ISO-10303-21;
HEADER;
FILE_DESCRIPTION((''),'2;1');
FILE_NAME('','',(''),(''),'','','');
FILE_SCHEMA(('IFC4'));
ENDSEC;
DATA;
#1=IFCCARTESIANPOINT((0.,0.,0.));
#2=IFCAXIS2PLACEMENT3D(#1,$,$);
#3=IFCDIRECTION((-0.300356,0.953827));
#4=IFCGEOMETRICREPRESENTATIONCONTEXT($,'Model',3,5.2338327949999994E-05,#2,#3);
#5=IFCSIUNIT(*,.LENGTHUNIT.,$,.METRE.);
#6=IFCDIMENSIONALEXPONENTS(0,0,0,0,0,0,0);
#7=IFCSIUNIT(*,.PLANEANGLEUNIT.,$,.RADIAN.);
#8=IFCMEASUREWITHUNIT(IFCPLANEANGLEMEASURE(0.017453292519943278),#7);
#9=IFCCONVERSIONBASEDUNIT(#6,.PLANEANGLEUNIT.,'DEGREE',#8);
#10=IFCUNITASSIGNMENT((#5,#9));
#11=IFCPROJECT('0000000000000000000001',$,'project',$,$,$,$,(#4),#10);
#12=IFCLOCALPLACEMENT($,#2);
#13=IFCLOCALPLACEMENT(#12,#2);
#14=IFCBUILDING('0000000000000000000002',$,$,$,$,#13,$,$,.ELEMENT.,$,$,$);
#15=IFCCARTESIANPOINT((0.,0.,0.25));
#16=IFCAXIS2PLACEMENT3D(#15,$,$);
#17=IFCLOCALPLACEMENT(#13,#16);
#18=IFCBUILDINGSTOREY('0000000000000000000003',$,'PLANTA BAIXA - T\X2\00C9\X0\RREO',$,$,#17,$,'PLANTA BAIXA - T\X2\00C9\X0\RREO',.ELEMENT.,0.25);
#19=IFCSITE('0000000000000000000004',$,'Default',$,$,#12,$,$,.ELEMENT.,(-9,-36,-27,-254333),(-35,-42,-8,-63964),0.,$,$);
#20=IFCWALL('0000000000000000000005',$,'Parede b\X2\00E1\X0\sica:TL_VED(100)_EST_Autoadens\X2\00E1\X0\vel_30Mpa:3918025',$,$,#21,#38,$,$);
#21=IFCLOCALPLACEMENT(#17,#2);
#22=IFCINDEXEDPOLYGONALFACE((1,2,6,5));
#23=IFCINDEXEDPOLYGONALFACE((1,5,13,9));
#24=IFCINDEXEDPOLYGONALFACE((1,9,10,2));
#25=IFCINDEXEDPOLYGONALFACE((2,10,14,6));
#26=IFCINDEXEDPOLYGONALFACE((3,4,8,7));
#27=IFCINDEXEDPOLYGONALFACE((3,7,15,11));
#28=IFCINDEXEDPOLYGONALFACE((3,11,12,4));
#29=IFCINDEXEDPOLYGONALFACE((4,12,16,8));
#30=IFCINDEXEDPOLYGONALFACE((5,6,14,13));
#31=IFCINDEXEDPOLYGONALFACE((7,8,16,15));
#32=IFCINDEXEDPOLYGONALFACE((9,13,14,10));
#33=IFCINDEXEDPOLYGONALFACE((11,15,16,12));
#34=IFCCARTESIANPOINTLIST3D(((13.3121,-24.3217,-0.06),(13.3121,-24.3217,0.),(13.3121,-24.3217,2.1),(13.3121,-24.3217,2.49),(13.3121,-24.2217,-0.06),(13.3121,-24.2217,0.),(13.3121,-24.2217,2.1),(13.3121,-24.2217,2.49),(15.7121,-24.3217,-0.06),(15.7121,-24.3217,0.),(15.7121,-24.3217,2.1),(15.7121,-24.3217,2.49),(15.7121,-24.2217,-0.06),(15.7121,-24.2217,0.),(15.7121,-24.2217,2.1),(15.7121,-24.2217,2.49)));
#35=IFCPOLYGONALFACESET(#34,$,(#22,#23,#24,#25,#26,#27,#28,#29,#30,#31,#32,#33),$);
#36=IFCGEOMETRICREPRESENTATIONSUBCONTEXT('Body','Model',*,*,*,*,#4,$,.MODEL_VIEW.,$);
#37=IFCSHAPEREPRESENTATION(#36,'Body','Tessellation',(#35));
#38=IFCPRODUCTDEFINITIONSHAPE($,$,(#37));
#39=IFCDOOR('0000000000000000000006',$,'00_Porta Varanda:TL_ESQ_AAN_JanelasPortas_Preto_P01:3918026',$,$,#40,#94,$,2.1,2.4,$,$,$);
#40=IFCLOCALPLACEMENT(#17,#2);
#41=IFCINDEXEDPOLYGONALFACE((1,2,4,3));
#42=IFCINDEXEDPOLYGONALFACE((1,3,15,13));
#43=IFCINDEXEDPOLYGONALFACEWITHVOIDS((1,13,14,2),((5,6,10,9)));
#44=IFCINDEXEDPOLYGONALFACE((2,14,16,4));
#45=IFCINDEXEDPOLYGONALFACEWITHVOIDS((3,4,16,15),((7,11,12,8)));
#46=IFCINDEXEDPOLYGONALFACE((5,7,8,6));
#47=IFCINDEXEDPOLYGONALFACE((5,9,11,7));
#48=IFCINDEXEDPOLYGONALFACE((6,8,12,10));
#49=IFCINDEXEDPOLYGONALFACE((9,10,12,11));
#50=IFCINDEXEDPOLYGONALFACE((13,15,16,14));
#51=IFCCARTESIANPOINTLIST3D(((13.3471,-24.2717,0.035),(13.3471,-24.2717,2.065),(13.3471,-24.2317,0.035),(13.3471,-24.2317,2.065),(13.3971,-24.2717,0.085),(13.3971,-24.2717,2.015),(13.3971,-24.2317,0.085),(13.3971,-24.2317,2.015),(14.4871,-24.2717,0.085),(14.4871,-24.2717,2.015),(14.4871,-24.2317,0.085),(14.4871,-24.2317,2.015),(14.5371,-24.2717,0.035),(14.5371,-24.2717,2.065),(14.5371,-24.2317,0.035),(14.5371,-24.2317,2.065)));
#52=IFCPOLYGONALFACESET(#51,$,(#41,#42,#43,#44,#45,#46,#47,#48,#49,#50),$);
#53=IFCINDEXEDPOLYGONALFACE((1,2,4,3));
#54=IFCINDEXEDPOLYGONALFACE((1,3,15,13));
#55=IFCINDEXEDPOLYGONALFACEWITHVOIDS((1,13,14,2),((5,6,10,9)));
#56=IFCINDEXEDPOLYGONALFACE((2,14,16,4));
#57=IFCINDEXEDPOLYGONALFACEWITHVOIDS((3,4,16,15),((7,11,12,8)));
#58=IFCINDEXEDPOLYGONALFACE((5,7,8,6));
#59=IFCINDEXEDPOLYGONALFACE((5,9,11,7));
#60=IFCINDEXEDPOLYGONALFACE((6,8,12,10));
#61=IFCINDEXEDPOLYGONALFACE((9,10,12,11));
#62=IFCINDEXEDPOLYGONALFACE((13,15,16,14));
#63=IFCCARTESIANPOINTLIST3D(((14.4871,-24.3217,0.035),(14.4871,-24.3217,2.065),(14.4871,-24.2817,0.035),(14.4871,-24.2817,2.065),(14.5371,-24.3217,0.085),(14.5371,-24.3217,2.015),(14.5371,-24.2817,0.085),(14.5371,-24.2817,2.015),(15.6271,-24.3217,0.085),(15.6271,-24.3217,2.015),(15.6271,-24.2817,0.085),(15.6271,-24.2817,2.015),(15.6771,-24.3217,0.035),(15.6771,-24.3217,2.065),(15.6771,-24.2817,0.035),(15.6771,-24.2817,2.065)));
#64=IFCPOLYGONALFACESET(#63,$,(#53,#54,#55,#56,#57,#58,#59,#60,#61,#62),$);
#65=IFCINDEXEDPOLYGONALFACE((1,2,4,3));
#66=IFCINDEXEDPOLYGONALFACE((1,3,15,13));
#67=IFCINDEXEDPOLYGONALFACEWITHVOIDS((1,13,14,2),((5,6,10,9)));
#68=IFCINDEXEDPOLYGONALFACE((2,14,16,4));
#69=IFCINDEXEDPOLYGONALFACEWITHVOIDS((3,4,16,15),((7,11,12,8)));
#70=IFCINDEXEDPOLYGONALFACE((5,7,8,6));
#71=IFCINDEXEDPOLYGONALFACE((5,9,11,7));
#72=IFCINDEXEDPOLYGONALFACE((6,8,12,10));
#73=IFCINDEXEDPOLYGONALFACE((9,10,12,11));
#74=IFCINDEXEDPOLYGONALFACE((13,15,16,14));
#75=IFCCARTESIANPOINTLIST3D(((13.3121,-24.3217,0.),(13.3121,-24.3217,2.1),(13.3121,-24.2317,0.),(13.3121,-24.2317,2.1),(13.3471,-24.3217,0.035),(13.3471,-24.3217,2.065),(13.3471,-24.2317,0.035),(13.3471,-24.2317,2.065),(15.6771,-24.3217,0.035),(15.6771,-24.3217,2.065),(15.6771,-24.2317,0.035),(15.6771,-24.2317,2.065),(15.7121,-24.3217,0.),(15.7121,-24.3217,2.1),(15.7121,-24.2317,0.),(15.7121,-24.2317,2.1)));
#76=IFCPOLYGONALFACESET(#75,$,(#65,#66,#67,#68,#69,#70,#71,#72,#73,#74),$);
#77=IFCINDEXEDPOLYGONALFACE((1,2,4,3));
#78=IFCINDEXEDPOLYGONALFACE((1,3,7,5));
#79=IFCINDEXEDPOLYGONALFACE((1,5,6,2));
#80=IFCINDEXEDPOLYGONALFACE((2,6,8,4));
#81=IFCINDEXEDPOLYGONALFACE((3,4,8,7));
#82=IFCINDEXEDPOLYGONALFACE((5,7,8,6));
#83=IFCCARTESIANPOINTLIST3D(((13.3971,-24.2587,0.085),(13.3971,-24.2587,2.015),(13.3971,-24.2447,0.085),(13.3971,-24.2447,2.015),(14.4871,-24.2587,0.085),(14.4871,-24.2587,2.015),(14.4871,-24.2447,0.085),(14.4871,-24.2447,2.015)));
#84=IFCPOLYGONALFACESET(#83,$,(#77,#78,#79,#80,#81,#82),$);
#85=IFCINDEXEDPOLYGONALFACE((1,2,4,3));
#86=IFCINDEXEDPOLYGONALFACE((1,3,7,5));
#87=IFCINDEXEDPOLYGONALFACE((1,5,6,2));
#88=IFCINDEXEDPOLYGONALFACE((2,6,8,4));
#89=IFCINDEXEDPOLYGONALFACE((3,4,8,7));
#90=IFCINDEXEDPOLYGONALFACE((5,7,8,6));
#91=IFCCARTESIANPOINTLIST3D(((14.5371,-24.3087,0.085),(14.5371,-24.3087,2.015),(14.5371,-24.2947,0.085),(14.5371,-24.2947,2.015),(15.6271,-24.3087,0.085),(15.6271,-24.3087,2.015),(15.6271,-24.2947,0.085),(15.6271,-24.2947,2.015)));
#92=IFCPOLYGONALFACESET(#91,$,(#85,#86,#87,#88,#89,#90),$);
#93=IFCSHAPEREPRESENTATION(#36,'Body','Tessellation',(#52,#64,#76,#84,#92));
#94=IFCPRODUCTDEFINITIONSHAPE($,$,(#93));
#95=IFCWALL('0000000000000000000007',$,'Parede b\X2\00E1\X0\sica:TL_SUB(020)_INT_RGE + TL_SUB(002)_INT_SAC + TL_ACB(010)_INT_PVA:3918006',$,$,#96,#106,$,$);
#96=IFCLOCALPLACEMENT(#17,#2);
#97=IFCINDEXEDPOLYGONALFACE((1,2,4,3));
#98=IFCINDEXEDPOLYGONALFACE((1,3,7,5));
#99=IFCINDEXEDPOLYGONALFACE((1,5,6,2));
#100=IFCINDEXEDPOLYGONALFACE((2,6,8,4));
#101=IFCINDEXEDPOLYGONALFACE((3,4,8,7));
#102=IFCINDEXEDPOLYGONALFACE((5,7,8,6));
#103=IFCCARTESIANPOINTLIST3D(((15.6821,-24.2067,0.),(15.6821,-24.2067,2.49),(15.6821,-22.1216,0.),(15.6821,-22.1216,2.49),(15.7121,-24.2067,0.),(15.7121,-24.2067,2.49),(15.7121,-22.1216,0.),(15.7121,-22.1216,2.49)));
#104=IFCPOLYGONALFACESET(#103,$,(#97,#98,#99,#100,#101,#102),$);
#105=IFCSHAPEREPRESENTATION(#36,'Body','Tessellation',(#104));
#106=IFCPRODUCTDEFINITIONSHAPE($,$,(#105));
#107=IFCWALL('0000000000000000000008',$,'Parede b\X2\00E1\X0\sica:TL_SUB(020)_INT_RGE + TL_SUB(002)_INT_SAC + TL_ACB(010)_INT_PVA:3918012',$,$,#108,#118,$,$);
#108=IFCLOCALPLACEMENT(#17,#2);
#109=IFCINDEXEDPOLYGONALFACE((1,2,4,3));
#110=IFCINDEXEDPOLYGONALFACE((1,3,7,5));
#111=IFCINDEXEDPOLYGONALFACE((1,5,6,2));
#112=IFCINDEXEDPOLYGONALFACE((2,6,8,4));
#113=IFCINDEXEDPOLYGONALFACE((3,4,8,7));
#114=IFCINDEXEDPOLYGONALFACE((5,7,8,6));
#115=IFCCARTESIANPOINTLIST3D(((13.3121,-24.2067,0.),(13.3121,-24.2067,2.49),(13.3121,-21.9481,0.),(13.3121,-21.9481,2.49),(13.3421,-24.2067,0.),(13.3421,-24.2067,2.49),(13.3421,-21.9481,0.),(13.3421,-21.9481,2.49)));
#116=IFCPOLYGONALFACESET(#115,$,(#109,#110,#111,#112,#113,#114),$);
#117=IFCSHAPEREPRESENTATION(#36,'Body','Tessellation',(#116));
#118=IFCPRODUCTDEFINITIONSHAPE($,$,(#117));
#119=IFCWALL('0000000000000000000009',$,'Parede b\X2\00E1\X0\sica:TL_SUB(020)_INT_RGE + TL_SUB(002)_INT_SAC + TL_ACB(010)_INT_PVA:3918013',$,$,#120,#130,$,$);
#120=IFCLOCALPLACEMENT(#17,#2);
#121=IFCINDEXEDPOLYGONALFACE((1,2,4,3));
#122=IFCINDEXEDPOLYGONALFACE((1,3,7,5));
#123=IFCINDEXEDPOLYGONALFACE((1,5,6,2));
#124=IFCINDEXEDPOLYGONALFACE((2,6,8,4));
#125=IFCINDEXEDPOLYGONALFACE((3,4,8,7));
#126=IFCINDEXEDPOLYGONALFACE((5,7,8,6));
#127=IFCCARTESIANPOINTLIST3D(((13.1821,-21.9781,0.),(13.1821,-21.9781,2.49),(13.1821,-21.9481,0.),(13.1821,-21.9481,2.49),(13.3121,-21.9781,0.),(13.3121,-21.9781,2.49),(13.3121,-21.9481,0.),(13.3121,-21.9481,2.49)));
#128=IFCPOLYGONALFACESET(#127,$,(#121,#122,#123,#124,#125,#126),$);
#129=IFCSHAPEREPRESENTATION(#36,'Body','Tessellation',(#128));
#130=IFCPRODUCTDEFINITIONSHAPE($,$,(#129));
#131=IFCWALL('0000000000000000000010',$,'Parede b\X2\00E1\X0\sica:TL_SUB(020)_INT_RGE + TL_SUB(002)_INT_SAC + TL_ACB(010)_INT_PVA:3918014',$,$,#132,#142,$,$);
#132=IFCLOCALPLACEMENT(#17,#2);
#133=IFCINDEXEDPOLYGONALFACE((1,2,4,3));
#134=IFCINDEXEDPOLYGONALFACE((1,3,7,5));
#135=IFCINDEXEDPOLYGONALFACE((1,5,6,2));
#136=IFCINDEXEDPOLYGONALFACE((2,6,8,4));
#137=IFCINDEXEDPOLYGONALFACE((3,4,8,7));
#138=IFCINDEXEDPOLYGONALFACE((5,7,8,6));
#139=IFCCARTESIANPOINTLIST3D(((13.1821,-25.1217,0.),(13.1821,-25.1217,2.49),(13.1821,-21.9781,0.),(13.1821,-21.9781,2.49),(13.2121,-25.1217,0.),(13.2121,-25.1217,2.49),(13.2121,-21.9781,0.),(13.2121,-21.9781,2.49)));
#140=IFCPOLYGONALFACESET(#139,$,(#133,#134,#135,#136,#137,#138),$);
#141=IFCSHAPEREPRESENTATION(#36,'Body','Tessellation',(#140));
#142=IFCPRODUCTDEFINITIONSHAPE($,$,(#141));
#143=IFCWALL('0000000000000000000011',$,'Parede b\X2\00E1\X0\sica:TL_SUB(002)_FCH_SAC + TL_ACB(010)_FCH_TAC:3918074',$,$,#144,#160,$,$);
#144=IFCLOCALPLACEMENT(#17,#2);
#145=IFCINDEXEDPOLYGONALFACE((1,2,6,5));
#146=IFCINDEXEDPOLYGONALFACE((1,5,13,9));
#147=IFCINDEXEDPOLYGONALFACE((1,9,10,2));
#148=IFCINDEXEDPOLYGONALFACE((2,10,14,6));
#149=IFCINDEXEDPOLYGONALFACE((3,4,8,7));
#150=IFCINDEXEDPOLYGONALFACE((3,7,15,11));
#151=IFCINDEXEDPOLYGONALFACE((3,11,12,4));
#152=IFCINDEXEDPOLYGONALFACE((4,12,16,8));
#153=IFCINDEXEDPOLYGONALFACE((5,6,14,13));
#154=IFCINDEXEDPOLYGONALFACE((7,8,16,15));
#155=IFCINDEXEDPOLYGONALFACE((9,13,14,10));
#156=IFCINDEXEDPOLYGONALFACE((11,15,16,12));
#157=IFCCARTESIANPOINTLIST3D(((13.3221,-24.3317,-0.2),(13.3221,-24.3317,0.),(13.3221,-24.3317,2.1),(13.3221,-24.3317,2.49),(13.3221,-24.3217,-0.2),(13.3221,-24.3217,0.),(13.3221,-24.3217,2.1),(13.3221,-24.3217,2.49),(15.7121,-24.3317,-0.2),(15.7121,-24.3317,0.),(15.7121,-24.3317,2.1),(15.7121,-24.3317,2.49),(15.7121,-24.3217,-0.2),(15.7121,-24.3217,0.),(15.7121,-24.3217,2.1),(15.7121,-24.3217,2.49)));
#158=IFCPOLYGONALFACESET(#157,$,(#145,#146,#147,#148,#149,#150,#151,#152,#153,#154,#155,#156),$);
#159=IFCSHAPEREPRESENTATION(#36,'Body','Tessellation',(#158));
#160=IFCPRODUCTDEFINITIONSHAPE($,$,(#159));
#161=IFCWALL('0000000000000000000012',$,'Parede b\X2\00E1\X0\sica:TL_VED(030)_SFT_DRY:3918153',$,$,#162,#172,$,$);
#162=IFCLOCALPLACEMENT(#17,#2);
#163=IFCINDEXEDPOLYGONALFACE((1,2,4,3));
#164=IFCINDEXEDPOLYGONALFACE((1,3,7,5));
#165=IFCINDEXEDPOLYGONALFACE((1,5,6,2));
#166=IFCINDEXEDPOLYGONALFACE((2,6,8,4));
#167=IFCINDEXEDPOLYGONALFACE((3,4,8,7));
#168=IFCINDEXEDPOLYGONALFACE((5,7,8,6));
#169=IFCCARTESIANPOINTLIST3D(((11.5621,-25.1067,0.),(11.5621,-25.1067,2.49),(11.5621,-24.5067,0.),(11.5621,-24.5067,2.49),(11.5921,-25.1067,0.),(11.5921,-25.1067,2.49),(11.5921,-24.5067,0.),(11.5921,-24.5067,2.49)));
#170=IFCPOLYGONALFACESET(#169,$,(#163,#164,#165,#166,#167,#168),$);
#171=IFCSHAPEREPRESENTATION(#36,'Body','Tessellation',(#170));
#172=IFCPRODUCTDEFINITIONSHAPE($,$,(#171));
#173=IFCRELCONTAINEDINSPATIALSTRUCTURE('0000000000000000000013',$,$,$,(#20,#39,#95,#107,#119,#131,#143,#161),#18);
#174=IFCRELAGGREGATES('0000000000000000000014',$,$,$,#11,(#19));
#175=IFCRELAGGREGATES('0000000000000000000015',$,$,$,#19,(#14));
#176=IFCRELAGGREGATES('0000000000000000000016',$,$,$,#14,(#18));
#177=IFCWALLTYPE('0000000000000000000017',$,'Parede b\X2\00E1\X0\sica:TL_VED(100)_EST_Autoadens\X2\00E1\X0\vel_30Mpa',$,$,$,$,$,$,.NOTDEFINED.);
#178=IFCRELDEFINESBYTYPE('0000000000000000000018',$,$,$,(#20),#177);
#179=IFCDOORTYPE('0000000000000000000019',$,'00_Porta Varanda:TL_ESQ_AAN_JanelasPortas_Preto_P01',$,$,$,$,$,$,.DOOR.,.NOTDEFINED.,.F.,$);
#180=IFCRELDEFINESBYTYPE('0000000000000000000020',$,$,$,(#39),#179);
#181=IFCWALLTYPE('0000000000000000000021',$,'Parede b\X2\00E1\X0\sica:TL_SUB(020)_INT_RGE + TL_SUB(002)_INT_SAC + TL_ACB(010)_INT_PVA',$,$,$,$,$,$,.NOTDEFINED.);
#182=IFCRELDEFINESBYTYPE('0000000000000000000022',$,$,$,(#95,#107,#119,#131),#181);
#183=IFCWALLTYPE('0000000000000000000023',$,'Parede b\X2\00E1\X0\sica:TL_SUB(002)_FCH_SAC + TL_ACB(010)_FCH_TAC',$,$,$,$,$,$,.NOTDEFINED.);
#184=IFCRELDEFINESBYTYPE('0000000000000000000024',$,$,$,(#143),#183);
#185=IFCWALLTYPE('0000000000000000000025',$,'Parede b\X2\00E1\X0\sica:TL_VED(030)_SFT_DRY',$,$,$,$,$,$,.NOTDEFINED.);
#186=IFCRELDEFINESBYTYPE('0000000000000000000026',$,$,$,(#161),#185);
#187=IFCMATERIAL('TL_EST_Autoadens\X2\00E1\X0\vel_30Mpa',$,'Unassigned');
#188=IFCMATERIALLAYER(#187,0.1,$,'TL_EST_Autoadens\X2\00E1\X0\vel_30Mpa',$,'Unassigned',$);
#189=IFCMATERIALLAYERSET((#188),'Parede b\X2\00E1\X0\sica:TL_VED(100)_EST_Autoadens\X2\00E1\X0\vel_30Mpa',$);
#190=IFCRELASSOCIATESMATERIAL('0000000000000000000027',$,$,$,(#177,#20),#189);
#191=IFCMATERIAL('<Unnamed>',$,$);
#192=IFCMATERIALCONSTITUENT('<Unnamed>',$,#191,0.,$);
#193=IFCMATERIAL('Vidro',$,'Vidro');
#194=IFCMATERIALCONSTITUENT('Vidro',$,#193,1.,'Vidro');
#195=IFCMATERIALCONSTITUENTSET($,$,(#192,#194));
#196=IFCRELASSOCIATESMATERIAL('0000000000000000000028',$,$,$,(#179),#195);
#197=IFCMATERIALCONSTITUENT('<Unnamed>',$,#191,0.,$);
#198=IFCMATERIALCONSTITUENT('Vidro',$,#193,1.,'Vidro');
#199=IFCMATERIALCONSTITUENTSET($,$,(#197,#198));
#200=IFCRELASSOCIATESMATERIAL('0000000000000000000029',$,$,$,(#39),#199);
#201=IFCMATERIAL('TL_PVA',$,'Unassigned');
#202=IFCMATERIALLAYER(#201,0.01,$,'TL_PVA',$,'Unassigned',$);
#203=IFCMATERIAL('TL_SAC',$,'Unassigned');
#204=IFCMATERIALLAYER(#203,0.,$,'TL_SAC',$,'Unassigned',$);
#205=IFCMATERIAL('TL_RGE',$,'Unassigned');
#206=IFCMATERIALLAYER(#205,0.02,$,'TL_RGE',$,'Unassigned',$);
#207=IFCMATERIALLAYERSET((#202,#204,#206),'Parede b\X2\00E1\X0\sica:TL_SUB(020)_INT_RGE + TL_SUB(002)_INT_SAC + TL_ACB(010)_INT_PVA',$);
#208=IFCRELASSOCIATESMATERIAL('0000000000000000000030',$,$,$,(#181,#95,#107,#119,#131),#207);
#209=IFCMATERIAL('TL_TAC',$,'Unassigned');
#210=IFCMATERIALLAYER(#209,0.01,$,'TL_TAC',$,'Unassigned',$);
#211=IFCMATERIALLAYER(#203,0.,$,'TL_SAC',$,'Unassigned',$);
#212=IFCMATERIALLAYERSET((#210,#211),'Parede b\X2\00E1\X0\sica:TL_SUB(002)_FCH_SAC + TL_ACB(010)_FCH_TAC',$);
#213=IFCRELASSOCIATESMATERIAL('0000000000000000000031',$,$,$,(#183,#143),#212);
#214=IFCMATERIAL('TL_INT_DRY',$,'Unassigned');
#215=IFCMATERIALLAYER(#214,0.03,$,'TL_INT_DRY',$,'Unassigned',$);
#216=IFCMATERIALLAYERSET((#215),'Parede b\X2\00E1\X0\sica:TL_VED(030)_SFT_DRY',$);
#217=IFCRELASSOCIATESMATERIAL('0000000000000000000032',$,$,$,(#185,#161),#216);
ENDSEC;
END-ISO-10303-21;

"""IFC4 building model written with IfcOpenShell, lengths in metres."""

from ifc_helpers import new_model, entity, si_unit, converted_unit, direction, frame, frame_2d, origin, place, context, subcontext, project, spatial, polyline, rectangle, outline, extrude, source, transform, mapped, material, layer, layer_set, layer_usage, constituent, constituent_set, type_object, type_shapes, element, fill, save


model = new_model("IFC4")

# Units and contexts
model_context = context("Model", 3, precision=5.2338327949999994e-05, world=origin(), true_north=direction((-0.300356, 0.953827)))
body_context = subcontext(model_context, "Body", "Model", "MODEL_VIEW")
ifc_project = project(units=[si_unit("LENGTHUNIT", "METRE"), converted_unit("PLANEANGLEUNIT", "DEGREE", entity("IfcPlaneAngleMeasure", 0.017453292519943278), si_unit("PLANEANGLEUNIT", "RADIAN"), dimensions=[0, 0, 0, 0, 0, 0, 0])], contexts=[model_context])

# Site, building, storey
site_placement = place(None, origin())
site = spatial("IfcSite", under=ifc_project, at=site_placement, Name="Default", CompositionType="ELEMENT", RefLatitude=(-9, -36, -27, -254333), RefLongitude=(-35, -42, -8, -63964), RefElevation=0.0)
building_placement = place(site_placement, origin())
building = spatial("IfcBuilding", under=site, at=building_placement, CompositionType="ELEMENT")
storey_placement = place(building_placement, frame((0.0, 0.0, 0.25)))
storey = spatial("IfcBuildingStorey", under=building, at=storey_placement, Name="PLANTA BAIXA - TÉRREO", LongName="PLANTA BAIXA - TÉRREO", CompositionType="ELEMENT", Elevation=0.25)

# Shared definitions
ifc_material_1 = material(Name="TL_EST_Autoadensável_30Mpa", Category="Unassigned")
ifc_layer_1 = layer(ifc_material_1, 0.1, Name="TL_EST_Autoadensável_30Mpa", Category="Unassigned")
ifc_layer_set_1 = layer_set([ifc_layer_1], Name="Parede básica:TL_VED(100)_EST_Autoadensável_30Mpa")
wall_type_1 = type_object("IfcWallType", Name="Parede básica:TL_VED(100)_EST_Autoadensável_30Mpa", PredefinedType="NOTDEFINED", material=ifc_layer_set_1)

# Shared definitions
ifc_material_2 = material(Name="Vidro", Category="Vidro")

# Wall, opening, door
ifc_layer_usage_1 = layer_usage(ifc_layer_set_1, "AXIS2", "NEGATIVE", 0.05)
wall_1_placement = place(storey_placement, frame((15.7121, -24.2717, -0.06), z_axis=(0.0, 0.0, 1.0), x_axis=(-1.0, 0.0, 0.0)))
wall_1 = element("IfcWall", 1, at=wall_1_placement, inside=storey, type_object=wall_type_1, material=ifc_layer_usage_1, Name="Parede básica:TL_VED(100)_EST_Autoadensável_30Mpa:3918025", context=body_context, shape_type="SweptSolid", body=[
    extrude(rectangle(XDim=2.4, YDim=0.1, at=frame_2d((1.2, 0.0), x_axis=(-1.0, 0.0))), origin(), (0.0, 0.0, 1.0), 2.55),
])
opening_1_placement = place(wall_1_placement, frame((2.4, 0.05, 0.06)))
opening_1 = element("IfcOpeningElement", 2, at=opening_1_placement, cuts=wall_1, PredefinedType="OPENING", context=body_context, shape_type="SweptSolid", body=[
    extrude(rectangle(XDim=2.1, YDim=2.4, at=frame_2d((1.05, 1.2), x_axis=(1.0, 0.0))), frame((0.0, 0.0, 0.0), z_axis=(0.0, -1.0, 0.0), x_axis=(0.0, 0.0, 1.0)), (0.0, 0.0, 1.0), 0.1),
])
ifc_material_3 = material(Name="<Unnamed>")
ifc_constituent_1 = constituent(ifc_material_3, Name="<Unnamed>", fraction=0.0)
ifc_constituent_2 = constituent(ifc_material_2, Name="Vidro", Category="Vidro", fraction=1.0)
ifc_constituent_set_1 = constituent_set(constituents=[ifc_constituent_1, ifc_constituent_2])
ifc_constituent_3 = constituent(ifc_material_3, Name="<Unnamed>", fraction=0.0)
ifc_constituent_4 = constituent(ifc_material_2, Name="Vidro", Category="Vidro", fraction=1.0)
ifc_constituent_set_2 = constituent_set(constituents=[ifc_constituent_3, ifc_constituent_4])
door_type = type_object("IfcDoorType", Name="00_Porta Varanda:TL_ESQ_AAN_JanelasPortas_Preto_P01", OperationType="NOTDEFINED", ParameterTakesPrecedence=False, PredefinedType="DOOR", material=ifc_constituent_set_2)
shared_shape_1 = source(origin(), body_context, "Body", "SweptSolid", [
    extrude(outline(polyline([(-0.595, -1.015), (0.595, -1.015), (0.595, 1.015), (-0.595, 1.015), (-0.595, -1.015)]), holes=[polyline([(-0.545, 0.965), (0.545, 0.965), (0.545, -0.965), (-0.545, -0.965), (-0.545, 0.965)])]), frame((0.63, 0.09, 1.05), z_axis=(0.0, -1.0, 0.0), x_axis=(-1.0, 0.0, 0.0)), (0.0, 0.0, 1.0), 0.04),
    extrude(outline(polyline([(-0.595, -1.015), (0.595, -1.015), (0.595, 1.015), (-0.595, 1.015), (-0.595, -1.015)]), holes=[polyline([(-0.545, 0.965), (0.545, 0.965), (0.545, -0.965), (-0.545, -0.965), (-0.545, 0.965)])]), frame((1.77, 0.04, 1.05), z_axis=(0.0, -1.0, 0.0), x_axis=(1.0, 0.0, 0.0)), (0.0, 0.0, 1.0), 0.04),
    extrude(outline(polyline([(-1.2, -1.05), (1.2, -1.05), (1.2, 1.05), (-1.2, 1.05), (-1.2, -1.05)]), holes=[polyline([(-1.165, 1.015), (1.165, 1.015), (1.165, -1.015), (-1.165, -1.015), (-1.165, 1.015)])]), frame((1.2, 0.09, 1.05), z_axis=(0.0, -1.0, 0.0), x_axis=(1.0, 0.0, 0.0)), (0.0, 0.0, 1.0), 0.09),
    extrude(rectangle(XDim=1.09, YDim=0.014, at=frame_2d((0.0, 0.0), x_axis=(1.0, 0.0))), frame((0.63, 0.07, 0.085), z_axis=(0.0, 0.0, 1.0), x_axis=(-1.0, 0.0, 0.0)), (0.0, 0.0, 1.0), 1.93),
    extrude(rectangle(XDim=1.09, YDim=0.014, at=frame_2d((0.0, 0.0), x_axis=(1.0, 0.0))), frame((1.77, 0.02, 0.085), z_axis=(0.0, 0.0, 1.0), x_axis=(-1.0, 0.0, 0.0)), (0.0, 0.0, 1.0), 1.93),
])
type_shapes(door_type, [shared_shape_1])
door_placement = place(opening_1_placement, frame((0.0, 0.0, 0.0), z_axis=(0.0, 0.0, 1.0), x_axis=(-1.0, 0.0, 0.0)))
door = element("IfcDoor", 3, at=door_placement, inside=storey, type_object=door_type, material=ifc_constituent_set_1, Name="00_Porta Varanda:TL_ESQ_AAN_JanelasPortas_Preto_P01:3918026", OverallHeight=2.1, OverallWidth=2.4, context=body_context, shape_type="MappedRepresentation", body=[
    mapped(shared_shape_1, transform((0.0, 0.0, 0.0), scale=1.0)),
])
fill(opening_1, door)

# Walls
ifc_material_4 = material(Name="TL_PVA", Category="Unassigned")
ifc_layer_2 = layer(ifc_material_4, 0.01, Name="TL_PVA", Category="Unassigned")
ifc_material_5 = material(Name="TL_SAC", Category="Unassigned")
ifc_layer_3 = layer(ifc_material_5, 0.0, Name="TL_SAC", Category="Unassigned")
ifc_material_6 = material(Name="TL_RGE", Category="Unassigned")
ifc_layer_4 = layer(ifc_material_6, 0.02, Name="TL_RGE", Category="Unassigned")
ifc_layer_set_2 = layer_set([ifc_layer_2, ifc_layer_3, ifc_layer_4], Name="Parede básica:TL_SUB(020)_INT_RGE + TL_SUB(002)_INT_SAC + TL_ACB(010)_INT_PVA")
ifc_layer_usage_2 = layer_usage(ifc_layer_set_2, "AXIS2", "NEGATIVE", 0.015)
wall_type_2 = type_object("IfcWallType", Name="Parede básica:TL_SUB(020)_INT_RGE + TL_SUB(002)_INT_SAC + TL_ACB(010)_INT_PVA", PredefinedType="NOTDEFINED", material=ifc_layer_set_2)
wall_2_placement = place(storey_placement, frame((15.6971, -24.2067, 0.0), z_axis=(0.0, 0.0, 1.0), x_axis=(0.0, 1.0, 0.0)))
element("IfcWall", 4, at=wall_2_placement, inside=storey, type_object=wall_type_2, material=ifc_layer_usage_2, Name="Parede básica:TL_SUB(020)_INT_RGE + TL_SUB(002)_INT_SAC + TL_ACB(010)_INT_PVA:3918006", context=body_context, shape_type="SweptSolid", body=[
    extrude(rectangle(XDim=2.0851, YDim=0.03, at=frame_2d((1.0426, 0.0), x_axis=(-1.0, 0.0))), origin(), (0.0, 0.0, 1.0), 2.49),
])
ifc_layer_usage_3 = layer_usage(ifc_layer_set_2, "AXIS2", "NEGATIVE", 0.015)
wall_3_placement = place(storey_placement, frame((13.3271, -21.9481, 0.0), z_axis=(0.0, 0.0, 1.0), x_axis=(0.0, -1.0, 0.0)))
element("IfcWall", 5, at=wall_3_placement, inside=storey, type_object=wall_type_2, material=ifc_layer_usage_3, Name="Parede básica:TL_SUB(020)_INT_RGE + TL_SUB(002)_INT_SAC + TL_ACB(010)_INT_PVA:3918012", context=body_context, shape_type="SweptSolid", body=[
    extrude(rectangle(XDim=2.2587, YDim=0.03, at=frame_2d((1.1293, 0.0), x_axis=(-1.0, 0.0))), origin(), (0.0, 0.0, 1.0), 2.49),
])
ifc_layer_usage_4 = layer_usage(ifc_layer_set_2, "AXIS2", "NEGATIVE", 0.015)
wall_4_placement = place(storey_placement, frame((13.1821, -21.9631, 0.0)))
element("IfcWall", 6, at=wall_4_placement, inside=storey, type_object=wall_type_2, material=ifc_layer_usage_4, Name="Parede básica:TL_SUB(020)_INT_RGE + TL_SUB(002)_INT_SAC + TL_ACB(010)_INT_PVA:3918013", context=body_context, shape_type="SweptSolid", body=[
    extrude(rectangle(XDim=0.13, YDim=0.03, at=frame_2d((0.065, 0.0), x_axis=(-1.0, 0.0))), origin(), (0.0, 0.0, 1.0), 2.49),
])
ifc_layer_usage_5 = layer_usage(ifc_layer_set_2, "AXIS2", "NEGATIVE", 0.015)
wall_5_placement = place(storey_placement, frame((13.1971, -25.1217, 0.0), z_axis=(0.0, 0.0, 1.0), x_axis=(0.0, 1.0, 0.0)))
element("IfcWall", 7, at=wall_5_placement, inside=storey, type_object=wall_type_2, material=ifc_layer_usage_5, Name="Parede básica:TL_SUB(020)_INT_RGE + TL_SUB(002)_INT_SAC + TL_ACB(010)_INT_PVA:3918014", context=body_context, shape_type="SweptSolid", body=[
    extrude(rectangle(XDim=3.1437, YDim=0.03, at=frame_2d((1.5718, 0.0), x_axis=(-1.0, 0.0))), origin(), (0.0, 0.0, 1.0), 2.49),
])

# Wall, opening
ifc_material_7 = material(Name="TL_TAC", Category="Unassigned")
ifc_layer_5 = layer(ifc_material_7, 0.01, Name="TL_TAC", Category="Unassigned")
ifc_layer_6 = layer(ifc_material_5, 0.0, Name="TL_SAC", Category="Unassigned")
ifc_layer_set_3 = layer_set([ifc_layer_5, ifc_layer_6], Name="Parede básica:TL_SUB(002)_FCH_SAC + TL_ACB(010)_FCH_TAC")
wall_type_3 = type_object("IfcWallType", Name="Parede básica:TL_SUB(002)_FCH_SAC + TL_ACB(010)_FCH_TAC", PredefinedType="NOTDEFINED", material=ifc_layer_set_3)
ifc_layer_usage_6 = layer_usage(ifc_layer_set_3, "AXIS2", "POSITIVE", -0.005)
wall_6_placement = place(storey_placement, frame((13.3221, -24.3267, -0.2)))
wall_6 = element("IfcWall", 8, at=wall_6_placement, inside=storey, type_object=wall_type_3, material=ifc_layer_usage_6, Name="Parede básica:TL_SUB(002)_FCH_SAC + TL_ACB(010)_FCH_TAC:3918074", context=body_context, shape_type="SweptSolid", body=[
    extrude(rectangle(XDim=2.39, YDim=0.01, at=frame_2d((1.195, 0.0), x_axis=(-1.0, 0.0))), origin(), (0.0, 0.0, 1.0), 2.69),
])
opening_2_placement = place(wall_6_placement, frame((-13.3221, 24.3267, 0.2)))
element("IfcOpeningElement", 9, at=opening_2_placement, cuts=wall_6, PredefinedType="OPENING", context=body_context, shape_type="SweptSolid", body=[
    extrude(rectangle(XDim=2.1, YDim=2.4, at=frame_2d((0.0, 0.0), x_axis=(0.0, 1.0))), frame((14.5121, -25.8457, 1.05), z_axis=(0.0, 1.0, 0.0), x_axis=(-1.0, 0.0, 0.0)), (0.0, 0.0, 1.0), 3.048),
])

# Wall
ifc_material_8 = material(Name="TL_INT_DRY", Category="Unassigned")
ifc_layer_7 = layer(ifc_material_8, 0.03, Name="TL_INT_DRY", Category="Unassigned")
ifc_layer_set_4 = layer_set([ifc_layer_7], Name="Parede básica:TL_VED(030)_SFT_DRY")
ifc_layer_usage_7 = layer_usage(ifc_layer_set_4, "AXIS2", "POSITIVE", -0.015)
wall_type_4 = type_object("IfcWallType", Name="Parede básica:TL_VED(030)_SFT_DRY", PredefinedType="NOTDEFINED", material=ifc_layer_set_4)
wall_7_placement = place(storey_placement, frame((11.5771, -25.1067, 0.0), z_axis=(0.0, 0.0, 1.0), x_axis=(0.0, 1.0, 0.0)))
element("IfcWall", 10, at=wall_7_placement, inside=storey, type_object=wall_type_4, material=ifc_layer_usage_7, Name="Parede básica:TL_VED(030)_SFT_DRY:3918153", context=body_context, shape_type="SweptSolid", body=[
    extrude(rectangle(XDim=0.6, YDim=0.03, at=frame_2d((0.3, 0.0), x_axis=(-1.0, 0.0))), origin(), (0.0, 0.0, 1.0), 2.49),
])

save(model, "model.ifc")
